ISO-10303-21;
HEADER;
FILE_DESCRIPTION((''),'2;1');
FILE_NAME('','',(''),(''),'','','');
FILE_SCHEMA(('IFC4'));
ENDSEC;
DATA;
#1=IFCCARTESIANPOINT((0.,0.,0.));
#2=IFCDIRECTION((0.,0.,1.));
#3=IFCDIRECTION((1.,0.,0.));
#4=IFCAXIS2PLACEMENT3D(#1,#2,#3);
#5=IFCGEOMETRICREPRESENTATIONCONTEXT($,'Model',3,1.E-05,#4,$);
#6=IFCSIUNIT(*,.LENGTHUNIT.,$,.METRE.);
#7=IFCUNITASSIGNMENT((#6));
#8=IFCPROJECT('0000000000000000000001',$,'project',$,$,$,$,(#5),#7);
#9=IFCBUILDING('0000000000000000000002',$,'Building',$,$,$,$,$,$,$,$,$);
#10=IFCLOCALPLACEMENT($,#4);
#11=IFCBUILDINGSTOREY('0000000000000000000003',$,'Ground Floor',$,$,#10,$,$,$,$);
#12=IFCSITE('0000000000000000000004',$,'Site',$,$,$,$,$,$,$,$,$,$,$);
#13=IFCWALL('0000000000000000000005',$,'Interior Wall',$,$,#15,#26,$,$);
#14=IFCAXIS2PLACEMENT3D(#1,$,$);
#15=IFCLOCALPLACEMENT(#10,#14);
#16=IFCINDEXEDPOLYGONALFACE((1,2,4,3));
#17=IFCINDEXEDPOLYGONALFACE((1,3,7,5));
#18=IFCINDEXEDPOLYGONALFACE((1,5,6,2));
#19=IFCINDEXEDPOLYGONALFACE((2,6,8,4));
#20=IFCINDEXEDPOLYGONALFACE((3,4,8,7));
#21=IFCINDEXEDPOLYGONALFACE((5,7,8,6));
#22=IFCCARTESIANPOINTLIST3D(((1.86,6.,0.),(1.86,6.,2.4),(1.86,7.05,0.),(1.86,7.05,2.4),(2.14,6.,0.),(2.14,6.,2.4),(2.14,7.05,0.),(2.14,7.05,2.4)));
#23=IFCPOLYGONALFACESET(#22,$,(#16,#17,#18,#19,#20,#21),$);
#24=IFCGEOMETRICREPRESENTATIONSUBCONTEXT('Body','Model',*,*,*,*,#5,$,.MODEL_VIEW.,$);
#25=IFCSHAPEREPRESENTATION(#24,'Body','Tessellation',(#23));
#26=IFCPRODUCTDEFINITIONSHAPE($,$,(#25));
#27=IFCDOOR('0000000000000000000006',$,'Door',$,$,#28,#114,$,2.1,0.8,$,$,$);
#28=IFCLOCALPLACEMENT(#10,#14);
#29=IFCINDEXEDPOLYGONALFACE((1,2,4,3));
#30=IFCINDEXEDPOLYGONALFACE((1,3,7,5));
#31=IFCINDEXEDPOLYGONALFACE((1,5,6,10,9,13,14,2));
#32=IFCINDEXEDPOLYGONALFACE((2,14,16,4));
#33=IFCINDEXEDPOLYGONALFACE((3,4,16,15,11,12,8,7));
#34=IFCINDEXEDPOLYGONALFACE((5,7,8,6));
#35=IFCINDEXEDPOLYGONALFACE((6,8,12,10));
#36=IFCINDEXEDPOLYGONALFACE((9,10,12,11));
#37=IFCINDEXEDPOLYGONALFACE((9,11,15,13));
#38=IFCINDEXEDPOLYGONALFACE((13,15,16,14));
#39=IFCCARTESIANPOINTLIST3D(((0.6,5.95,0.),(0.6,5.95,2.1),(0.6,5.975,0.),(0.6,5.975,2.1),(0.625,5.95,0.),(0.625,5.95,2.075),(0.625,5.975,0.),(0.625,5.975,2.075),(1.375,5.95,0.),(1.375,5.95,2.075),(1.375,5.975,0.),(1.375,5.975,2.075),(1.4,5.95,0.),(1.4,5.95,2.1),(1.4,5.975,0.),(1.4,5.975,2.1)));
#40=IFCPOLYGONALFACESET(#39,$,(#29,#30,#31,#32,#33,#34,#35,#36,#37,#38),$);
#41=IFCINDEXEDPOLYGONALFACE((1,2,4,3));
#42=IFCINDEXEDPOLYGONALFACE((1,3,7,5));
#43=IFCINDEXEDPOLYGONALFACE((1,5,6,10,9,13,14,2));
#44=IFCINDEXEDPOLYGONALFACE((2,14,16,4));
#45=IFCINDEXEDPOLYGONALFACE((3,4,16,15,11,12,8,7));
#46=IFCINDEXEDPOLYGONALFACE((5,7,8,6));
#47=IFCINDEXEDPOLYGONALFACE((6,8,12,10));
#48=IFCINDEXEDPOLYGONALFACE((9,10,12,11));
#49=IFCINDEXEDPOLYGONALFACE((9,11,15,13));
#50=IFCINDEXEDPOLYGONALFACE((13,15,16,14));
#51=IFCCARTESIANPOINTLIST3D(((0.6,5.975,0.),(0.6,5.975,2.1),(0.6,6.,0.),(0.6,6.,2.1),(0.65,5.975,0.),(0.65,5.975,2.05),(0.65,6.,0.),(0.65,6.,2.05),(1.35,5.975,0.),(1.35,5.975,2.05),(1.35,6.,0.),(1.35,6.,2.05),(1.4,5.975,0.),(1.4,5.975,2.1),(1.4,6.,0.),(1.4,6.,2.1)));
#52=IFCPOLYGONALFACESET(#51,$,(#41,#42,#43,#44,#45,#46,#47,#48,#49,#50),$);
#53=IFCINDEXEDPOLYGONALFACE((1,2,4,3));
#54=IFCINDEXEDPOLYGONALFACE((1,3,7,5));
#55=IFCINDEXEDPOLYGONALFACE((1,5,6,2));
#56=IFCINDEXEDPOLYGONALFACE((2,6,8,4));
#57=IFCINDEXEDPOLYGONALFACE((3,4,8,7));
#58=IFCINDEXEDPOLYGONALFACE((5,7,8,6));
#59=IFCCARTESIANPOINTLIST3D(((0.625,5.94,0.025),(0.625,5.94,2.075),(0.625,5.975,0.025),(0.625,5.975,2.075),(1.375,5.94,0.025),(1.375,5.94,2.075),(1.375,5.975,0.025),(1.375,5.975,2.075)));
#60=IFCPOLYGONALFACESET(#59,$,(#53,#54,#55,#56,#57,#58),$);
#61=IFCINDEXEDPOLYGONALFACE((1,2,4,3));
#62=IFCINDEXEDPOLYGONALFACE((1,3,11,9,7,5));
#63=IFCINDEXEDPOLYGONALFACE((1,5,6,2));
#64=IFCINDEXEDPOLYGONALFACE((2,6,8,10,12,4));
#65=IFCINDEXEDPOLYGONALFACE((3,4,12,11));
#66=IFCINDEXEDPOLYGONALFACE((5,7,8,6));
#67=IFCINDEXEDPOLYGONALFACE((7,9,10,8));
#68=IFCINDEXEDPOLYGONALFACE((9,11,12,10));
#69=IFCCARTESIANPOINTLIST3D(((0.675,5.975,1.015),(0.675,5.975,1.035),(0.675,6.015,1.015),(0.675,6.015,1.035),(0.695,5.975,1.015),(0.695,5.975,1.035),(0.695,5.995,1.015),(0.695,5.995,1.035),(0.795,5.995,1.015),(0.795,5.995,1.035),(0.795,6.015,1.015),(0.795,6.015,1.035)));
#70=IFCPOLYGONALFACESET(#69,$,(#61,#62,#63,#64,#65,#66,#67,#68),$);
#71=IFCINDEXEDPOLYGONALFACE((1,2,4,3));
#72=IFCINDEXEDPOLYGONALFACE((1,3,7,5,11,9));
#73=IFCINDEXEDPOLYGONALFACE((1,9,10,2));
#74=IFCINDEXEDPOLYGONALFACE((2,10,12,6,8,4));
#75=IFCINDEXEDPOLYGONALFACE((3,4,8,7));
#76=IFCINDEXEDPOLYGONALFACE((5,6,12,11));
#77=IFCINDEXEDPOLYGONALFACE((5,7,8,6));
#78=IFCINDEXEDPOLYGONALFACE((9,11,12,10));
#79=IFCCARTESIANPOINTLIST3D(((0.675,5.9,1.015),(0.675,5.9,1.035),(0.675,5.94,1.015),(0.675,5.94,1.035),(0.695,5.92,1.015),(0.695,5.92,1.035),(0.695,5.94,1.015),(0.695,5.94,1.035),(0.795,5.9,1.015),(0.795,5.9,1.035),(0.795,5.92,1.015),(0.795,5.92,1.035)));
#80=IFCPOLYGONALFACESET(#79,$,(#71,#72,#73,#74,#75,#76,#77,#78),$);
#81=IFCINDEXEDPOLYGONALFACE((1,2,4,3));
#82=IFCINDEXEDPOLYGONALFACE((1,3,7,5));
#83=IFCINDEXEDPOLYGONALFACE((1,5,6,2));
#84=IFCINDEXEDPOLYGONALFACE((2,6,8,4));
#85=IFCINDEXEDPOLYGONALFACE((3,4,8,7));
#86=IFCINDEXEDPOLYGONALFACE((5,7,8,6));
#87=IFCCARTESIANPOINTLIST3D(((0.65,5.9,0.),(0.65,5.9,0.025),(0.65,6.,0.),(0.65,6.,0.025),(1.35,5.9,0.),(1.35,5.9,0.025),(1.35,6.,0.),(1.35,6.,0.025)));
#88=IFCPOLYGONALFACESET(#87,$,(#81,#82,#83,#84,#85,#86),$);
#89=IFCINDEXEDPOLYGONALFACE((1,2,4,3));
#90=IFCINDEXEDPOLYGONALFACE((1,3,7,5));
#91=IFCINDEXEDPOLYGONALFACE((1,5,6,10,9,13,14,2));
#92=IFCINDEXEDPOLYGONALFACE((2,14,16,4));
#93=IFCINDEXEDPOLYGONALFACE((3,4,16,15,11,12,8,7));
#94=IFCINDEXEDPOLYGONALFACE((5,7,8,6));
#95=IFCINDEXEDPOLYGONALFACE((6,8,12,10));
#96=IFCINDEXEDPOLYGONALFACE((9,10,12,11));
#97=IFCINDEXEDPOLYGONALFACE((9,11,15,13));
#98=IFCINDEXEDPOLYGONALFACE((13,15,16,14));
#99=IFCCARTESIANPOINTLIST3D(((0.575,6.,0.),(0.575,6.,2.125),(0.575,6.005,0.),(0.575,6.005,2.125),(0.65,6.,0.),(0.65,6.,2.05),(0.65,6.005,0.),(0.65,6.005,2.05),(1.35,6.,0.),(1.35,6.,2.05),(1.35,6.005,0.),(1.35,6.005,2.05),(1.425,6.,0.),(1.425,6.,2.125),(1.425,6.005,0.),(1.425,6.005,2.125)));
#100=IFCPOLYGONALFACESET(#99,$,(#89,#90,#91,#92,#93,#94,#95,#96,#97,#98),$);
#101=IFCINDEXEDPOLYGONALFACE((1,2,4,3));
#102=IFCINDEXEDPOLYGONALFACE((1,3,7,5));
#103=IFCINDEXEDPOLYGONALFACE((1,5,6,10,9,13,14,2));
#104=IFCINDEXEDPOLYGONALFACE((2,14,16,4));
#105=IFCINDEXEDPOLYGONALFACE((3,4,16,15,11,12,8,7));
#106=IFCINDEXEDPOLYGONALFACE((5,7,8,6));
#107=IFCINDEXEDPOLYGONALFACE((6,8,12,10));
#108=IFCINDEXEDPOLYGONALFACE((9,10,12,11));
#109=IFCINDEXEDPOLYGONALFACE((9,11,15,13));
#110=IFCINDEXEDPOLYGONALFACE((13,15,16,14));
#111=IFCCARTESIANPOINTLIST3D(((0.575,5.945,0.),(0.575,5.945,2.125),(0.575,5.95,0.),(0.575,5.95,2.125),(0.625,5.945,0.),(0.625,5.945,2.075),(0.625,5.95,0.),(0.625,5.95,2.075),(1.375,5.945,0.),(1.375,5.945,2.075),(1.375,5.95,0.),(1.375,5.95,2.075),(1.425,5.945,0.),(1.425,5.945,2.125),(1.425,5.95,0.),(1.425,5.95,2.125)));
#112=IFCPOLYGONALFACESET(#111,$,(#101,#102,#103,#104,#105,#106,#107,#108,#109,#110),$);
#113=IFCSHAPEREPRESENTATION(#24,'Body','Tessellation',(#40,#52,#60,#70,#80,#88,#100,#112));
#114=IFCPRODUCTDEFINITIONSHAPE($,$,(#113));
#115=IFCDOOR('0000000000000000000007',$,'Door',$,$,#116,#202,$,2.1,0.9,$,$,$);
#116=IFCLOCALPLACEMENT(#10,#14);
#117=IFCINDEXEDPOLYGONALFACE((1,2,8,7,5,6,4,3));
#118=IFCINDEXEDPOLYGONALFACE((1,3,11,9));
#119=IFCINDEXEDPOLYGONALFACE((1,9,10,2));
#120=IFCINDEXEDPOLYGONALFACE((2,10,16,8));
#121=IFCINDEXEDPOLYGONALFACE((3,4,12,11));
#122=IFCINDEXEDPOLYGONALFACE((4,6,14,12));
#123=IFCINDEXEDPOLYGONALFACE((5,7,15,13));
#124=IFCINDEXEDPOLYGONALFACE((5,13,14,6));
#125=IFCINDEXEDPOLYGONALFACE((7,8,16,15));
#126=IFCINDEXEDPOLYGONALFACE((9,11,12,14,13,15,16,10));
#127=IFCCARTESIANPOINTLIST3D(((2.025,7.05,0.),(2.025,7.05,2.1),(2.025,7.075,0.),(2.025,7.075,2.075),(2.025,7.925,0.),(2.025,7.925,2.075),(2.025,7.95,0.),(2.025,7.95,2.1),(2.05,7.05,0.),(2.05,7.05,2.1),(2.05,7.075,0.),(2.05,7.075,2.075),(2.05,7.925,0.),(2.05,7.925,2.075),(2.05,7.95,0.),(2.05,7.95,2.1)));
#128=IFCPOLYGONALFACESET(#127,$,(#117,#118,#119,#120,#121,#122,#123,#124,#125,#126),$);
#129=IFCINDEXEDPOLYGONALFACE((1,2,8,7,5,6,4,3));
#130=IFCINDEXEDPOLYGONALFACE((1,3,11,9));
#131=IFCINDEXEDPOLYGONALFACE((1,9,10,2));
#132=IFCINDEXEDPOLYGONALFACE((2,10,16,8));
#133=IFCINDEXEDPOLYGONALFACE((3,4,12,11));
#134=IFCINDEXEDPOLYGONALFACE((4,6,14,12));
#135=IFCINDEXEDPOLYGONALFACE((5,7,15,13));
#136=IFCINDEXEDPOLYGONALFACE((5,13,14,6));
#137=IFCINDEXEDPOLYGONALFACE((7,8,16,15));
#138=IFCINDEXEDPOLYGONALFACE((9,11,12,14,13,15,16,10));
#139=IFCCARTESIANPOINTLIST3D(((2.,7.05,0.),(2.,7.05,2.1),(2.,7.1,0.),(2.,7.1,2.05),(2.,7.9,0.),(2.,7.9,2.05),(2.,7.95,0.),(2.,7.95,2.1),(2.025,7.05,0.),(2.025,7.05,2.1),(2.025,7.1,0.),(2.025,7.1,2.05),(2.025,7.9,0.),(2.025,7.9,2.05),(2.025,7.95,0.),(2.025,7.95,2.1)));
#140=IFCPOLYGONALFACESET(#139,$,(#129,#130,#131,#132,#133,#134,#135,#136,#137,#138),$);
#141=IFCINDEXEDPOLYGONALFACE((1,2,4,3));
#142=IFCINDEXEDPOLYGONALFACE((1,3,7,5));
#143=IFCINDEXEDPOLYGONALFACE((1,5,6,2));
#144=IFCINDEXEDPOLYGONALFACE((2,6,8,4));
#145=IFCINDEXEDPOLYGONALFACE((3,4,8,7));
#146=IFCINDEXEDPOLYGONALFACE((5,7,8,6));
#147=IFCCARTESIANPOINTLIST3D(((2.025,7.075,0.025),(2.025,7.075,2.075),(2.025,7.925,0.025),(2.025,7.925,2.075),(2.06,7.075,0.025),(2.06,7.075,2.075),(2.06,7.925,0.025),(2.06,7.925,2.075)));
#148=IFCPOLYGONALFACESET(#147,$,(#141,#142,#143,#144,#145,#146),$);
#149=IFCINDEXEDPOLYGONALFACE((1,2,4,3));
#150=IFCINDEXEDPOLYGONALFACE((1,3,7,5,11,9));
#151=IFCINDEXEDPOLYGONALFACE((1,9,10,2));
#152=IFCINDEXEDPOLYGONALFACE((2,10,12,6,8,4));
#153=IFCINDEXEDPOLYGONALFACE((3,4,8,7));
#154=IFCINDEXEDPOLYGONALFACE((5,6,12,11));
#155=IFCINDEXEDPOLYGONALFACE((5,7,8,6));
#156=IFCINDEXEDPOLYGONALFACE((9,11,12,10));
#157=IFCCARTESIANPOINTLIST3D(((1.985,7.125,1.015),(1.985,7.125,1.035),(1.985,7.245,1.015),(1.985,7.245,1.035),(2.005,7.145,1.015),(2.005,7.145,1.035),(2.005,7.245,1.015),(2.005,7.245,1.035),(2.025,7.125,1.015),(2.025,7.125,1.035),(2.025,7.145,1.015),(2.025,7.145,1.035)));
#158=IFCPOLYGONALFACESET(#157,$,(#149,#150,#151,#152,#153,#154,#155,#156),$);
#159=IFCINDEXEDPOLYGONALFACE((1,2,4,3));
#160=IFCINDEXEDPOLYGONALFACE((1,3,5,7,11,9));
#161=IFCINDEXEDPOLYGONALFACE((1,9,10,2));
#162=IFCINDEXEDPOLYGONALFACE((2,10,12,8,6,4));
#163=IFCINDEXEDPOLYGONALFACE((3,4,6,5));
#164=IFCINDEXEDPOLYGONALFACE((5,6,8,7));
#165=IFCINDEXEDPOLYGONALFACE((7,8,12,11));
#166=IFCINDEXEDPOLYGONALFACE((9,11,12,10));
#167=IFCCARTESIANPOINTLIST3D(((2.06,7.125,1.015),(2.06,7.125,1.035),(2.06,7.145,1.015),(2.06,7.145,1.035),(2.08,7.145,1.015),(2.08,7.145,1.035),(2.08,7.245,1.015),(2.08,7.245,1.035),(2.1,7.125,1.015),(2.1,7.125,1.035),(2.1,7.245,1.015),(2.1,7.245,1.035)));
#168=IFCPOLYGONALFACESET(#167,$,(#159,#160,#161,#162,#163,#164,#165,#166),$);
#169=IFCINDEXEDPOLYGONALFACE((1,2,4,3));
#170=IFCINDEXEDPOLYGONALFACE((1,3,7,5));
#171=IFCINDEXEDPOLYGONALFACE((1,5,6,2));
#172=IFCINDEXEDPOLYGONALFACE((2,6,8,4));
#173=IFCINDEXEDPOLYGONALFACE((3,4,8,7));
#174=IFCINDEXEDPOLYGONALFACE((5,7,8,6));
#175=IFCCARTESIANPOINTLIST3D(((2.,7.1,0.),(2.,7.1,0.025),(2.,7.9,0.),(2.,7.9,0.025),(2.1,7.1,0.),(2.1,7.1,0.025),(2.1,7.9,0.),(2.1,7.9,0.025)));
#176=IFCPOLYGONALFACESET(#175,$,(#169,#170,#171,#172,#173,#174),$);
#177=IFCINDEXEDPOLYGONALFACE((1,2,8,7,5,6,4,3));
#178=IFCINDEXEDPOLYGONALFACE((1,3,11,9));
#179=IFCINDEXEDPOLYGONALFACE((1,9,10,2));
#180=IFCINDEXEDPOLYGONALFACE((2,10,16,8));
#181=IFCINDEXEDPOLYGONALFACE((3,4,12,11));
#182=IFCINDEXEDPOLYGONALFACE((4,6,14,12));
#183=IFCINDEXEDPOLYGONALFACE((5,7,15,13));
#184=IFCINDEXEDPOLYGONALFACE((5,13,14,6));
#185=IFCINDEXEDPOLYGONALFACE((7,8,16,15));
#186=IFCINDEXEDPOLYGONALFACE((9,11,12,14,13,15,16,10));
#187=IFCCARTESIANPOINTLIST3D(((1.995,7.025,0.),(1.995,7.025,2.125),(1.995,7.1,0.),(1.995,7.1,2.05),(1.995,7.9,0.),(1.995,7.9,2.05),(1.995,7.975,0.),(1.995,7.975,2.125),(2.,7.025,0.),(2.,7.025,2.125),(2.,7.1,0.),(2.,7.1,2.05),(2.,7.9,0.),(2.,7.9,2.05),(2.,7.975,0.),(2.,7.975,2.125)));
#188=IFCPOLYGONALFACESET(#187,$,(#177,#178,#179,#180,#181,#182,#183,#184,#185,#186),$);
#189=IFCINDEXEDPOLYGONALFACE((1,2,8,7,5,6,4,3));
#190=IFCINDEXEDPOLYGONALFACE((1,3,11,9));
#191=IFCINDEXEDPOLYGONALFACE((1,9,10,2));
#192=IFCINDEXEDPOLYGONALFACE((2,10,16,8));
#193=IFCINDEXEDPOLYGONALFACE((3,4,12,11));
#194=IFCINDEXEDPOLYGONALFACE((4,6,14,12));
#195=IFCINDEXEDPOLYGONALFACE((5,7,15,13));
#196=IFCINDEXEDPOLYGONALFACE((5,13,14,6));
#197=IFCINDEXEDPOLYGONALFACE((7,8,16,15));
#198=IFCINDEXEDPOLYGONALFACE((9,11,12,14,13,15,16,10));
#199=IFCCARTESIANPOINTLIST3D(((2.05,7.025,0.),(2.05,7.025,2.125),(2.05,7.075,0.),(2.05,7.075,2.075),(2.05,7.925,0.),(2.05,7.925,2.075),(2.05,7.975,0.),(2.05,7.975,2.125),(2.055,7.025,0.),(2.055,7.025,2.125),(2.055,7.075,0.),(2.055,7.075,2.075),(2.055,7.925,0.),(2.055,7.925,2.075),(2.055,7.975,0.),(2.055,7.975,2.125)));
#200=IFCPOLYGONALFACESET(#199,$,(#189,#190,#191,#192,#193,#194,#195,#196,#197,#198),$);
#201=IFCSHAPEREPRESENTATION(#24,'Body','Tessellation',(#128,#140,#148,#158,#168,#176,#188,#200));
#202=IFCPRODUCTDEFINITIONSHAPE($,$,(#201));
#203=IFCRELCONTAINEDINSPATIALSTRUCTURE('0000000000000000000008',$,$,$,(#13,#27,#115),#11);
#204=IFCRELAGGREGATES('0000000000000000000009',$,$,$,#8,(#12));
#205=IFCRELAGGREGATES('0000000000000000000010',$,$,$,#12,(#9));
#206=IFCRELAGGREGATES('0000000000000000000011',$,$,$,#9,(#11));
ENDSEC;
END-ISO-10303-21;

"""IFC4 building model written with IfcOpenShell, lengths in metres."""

from ifc_helpers import new_model, si_unit, frame, origin_with_axes, place, context, subcontext, project, spatial, line, indexed_curve, outline, extrude, element, save


model = new_model("IFC4")

# Units and contexts
model_context = context("Model", 3, precision=1e-05, world=origin_with_axes())
body_context = subcontext(model_context, "Body", "Model", "MODEL_VIEW")
ifc_project = project(units=[si_unit("LENGTHUNIT", "METRE")], contexts=[model_context])

# Site, building, storey
site = spatial("IfcSite", under=ifc_project, Name="Site")
building = spatial("IfcBuilding", under=site, Name="Building")
storey_placement = place(None, origin_with_axes())
storey = spatial("IfcBuildingStorey", under=building, at=storey_placement, Name="Ground Floor")

# Wall
for number, where, z_axis, x_axis, name in (
    (1, (2.0, 7.05, 0.0), (0.0, 0.0, 1.0), (0.0, -1.0, 0.0), "Interior Wall"),
):
    element("IfcWall", number, at=place(storey_placement, frame(where, z_axis=z_axis, x_axis=x_axis)), inside=storey, Name=name, context=body_context, shape_type="SweptSolid", body=[
        extrude(outline(indexed_curve([(0.0, 0.0), (0.0, 0.28), (1.05, 0.28), (1.05, 0.0), (0.0, 0.0)], self_intersect=False)), frame((0.0, -0.14, 0.0), z_axis=(0.0, 0.0, 1.0), x_axis=(1.0, 0.0, 0.0)), (0.0, 0.0, 1.0), 2.4),
    ])

# Doors
door_1_placement = place(storey_placement, frame((1.4, 6.0, 0.0), z_axis=(0.0, 0.0, 1.0), x_axis=(-1.0, 0.0, 0.0)))
element("IfcDoor", 2, at=door_1_placement, inside=storey, Name="Door", OverallHeight=2.1, OverallWidth=0.8, context=body_context, shape_type="SweptSolid", body=[
    extrude(outline(indexed_curve([(0.0, 0.0), (0.0, 2.1), (0.8, 2.1), (0.8, 0.0), (0.775, 0.0), (0.775, 2.075), (0.025, 2.075), (0.025, 0.0)], segments=[line(1, 2, 3, 4, 5, 6, 7, 8, 1)])), frame((0.0, 0.025, 0.0), z_axis=(0.0, -1.0, 0.0), x_axis=(1.0, 0.0, 0.0)), (0.0, 0.0, -1.0), 0.025),
    extrude(outline(indexed_curve([(0.0, 0.0), (0.0, 2.1), (0.8, 2.1), (0.8, 0.0), (0.75, 0.0), (0.75, 2.05), (0.05, 2.05), (0.05, 0.0)], segments=[line(1, 2, 3, 4, 5, 6, 7, 8, 1)])), frame((0.0, 0.0, 0.0), z_axis=(0.0, -1.0, 0.0), x_axis=(1.0, 0.0, 0.0)), (0.0, 0.0, -1.0), 0.025),
    extrude(outline(indexed_curve([(0.0, 0.0), (0.75, 0.0), (0.75, 0.035), (0.0, 0.035)], segments=[line(1, 2, 3, 4, 1)])), frame((0.025, 0.025, 0.025), z_axis=(0.0, 0.0, 1.0), x_axis=(1.0, 0.0, 0.0)), (0.0, 0.0, 1.0), 2.05),
    extrude(outline(indexed_curve([(0.0, 0.0), (0.0, -0.04), (-0.12, -0.04), (-0.12, -0.02), (-0.02, -0.02), (-0.02, 0.0)], segments=[line(1, 2, 3, 4, 5, 6, 1)])), frame((0.725, 0.025, 1.015), z_axis=(0.0, 0.0, 1.0), x_axis=(1.0, 0.0, 0.0)), (0.0, 0.0, 1.0), 0.02),
    extrude(outline(indexed_curve([(0.0, 0.0), (0.0, 0.04), (-0.12, 0.04), (-0.12, 0.02), (-0.02, 0.02), (-0.02, 0.0)], segments=[line(1, 2, 3, 4, 5, 6, 1)])), frame((0.725, 0.06, 1.015), z_axis=(0.0, 0.0, 1.0), x_axis=(1.0, 0.0, 0.0)), (0.0, 0.0, 1.0), 0.02),
    extrude(outline(indexed_curve([(0.0, 0.0), (0.7, 0.0), (0.7, 0.1), (0.0, 0.1)], segments=[line(1, 2, 3, 4, 1)])), frame((0.05, 0.0, 0.0), z_axis=(0.0, 0.0, 1.0), x_axis=(1.0, 0.0, 0.0)), (0.0, 0.0, 1.0), 0.025),
    extrude(outline(indexed_curve([(0.0, 0.0), (0.0, 2.125), (0.85, 2.125), (0.85, 0.0), (0.775, 0.0), (0.775, 2.05), (0.075, 2.05), (0.075, 0.0)], segments=[line(1, 2, 3, 4, 5, 6, 7, 8, 1)])), frame((-0.025, -0.005, 0.0), z_axis=(0.0, -1.0, 0.0), x_axis=(1.0, 0.0, 0.0)), (0.0, 0.0, -1.0), 0.005),
    extrude(outline(indexed_curve([(0.0, 0.0), (0.0, 2.125), (0.85, 2.125), (0.85, 0.0), (0.8, 0.0), (0.8, 2.075), (0.05, 2.075), (0.05, 0.0)], segments=[line(1, 2, 3, 4, 5, 6, 7, 8, 1)])), frame((-0.025, 0.05, 0.0), z_axis=(0.0, -1.0, 0.0), x_axis=(1.0, 0.0, 0.0)), (0.0, 0.0, -1.0), 0.005),
])
door_2_placement = place(storey_placement, frame((2.0, 7.95, 0.0), z_axis=(0.0, 0.0, 1.0), x_axis=(0.0, -1.0, 0.0)))
element("IfcDoor", 3, at=door_2_placement, inside=storey, Name="Door", OverallHeight=2.1, OverallWidth=0.9, context=body_context, shape_type="SweptSolid", body=[
    extrude(outline(indexed_curve([(0.0, 0.0), (0.0, 2.1), (0.9, 2.1), (0.9, 0.0), (0.875, 0.0), (0.875, 2.075), (0.025, 2.075), (0.025, 0.0)], segments=[line(1, 2, 3, 4, 5, 6, 7, 8, 1)])), frame((0.0, 0.025, 0.0), z_axis=(0.0, -1.0, 0.0), x_axis=(1.0, 0.0, 0.0)), (0.0, 0.0, -1.0), 0.025),
    extrude(outline(indexed_curve([(0.0, 0.0), (0.0, 2.1), (0.9, 2.1), (0.9, 0.0), (0.85, 0.0), (0.85, 2.05), (0.05, 2.05), (0.05, 0.0)], segments=[line(1, 2, 3, 4, 5, 6, 7, 8, 1)])), frame((0.0, 0.0, 0.0), z_axis=(0.0, -1.0, 0.0), x_axis=(1.0, 0.0, 0.0)), (0.0, 0.0, -1.0), 0.025),
    extrude(outline(indexed_curve([(0.0, 0.0), (0.85, 0.0), (0.85, 0.035), (0.0, 0.035)], segments=[line(1, 2, 3, 4, 1)])), frame((0.025, 0.025, 0.025), z_axis=(0.0, 0.0, 1.0), x_axis=(1.0, 0.0, 0.0)), (0.0, 0.0, 1.0), 2.05),
    extrude(outline(indexed_curve([(0.0, 0.0), (0.0, -0.04), (-0.12, -0.04), (-0.12, -0.02), (-0.02, -0.02), (-0.02, 0.0)], segments=[line(1, 2, 3, 4, 5, 6, 1)])), frame((0.825, 0.025, 1.015), z_axis=(0.0, 0.0, 1.0), x_axis=(1.0, 0.0, 0.0)), (0.0, 0.0, 1.0), 0.02),
    extrude(outline(indexed_curve([(0.0, 0.0), (0.0, 0.04), (-0.12, 0.04), (-0.12, 0.02), (-0.02, 0.02), (-0.02, 0.0)], segments=[line(1, 2, 3, 4, 5, 6, 1)])), frame((0.825, 0.06, 1.015), z_axis=(0.0, 0.0, 1.0), x_axis=(1.0, 0.0, 0.0)), (0.0, 0.0, 1.0), 0.02),
    extrude(outline(indexed_curve([(0.0, 0.0), (0.8, 0.0), (0.8, 0.1), (0.0, 0.1)], segments=[line(1, 2, 3, 4, 1)])), frame((0.05, 0.0, 0.0), z_axis=(0.0, 0.0, 1.0), x_axis=(1.0, 0.0, 0.0)), (0.0, 0.0, 1.0), 0.025),
    extrude(outline(indexed_curve([(0.0, 0.0), (0.0, 2.125), (0.95, 2.125), (0.95, 0.0), (0.875, 0.0), (0.875, 2.05), (0.075, 2.05), (0.075, 0.0)], segments=[line(1, 2, 3, 4, 5, 6, 7, 8, 1)])), frame((-0.025, -0.005, 0.0), z_axis=(0.0, -1.0, 0.0), x_axis=(1.0, 0.0, 0.0)), (0.0, 0.0, -1.0), 0.005),
    extrude(outline(indexed_curve([(0.0, 0.0), (0.0, 2.125), (0.95, 2.125), (0.95, 0.0), (0.9, 0.0), (0.9, 2.075), (0.05, 2.075), (0.05, 0.0)], segments=[line(1, 2, 3, 4, 5, 6, 7, 8, 1)])), frame((-0.025, 0.05, 0.0), z_axis=(0.0, -1.0, 0.0), x_axis=(1.0, 0.0, 0.0)), (0.0, 0.0, -1.0), 0.005),
])

save(model, "model.ifc")
